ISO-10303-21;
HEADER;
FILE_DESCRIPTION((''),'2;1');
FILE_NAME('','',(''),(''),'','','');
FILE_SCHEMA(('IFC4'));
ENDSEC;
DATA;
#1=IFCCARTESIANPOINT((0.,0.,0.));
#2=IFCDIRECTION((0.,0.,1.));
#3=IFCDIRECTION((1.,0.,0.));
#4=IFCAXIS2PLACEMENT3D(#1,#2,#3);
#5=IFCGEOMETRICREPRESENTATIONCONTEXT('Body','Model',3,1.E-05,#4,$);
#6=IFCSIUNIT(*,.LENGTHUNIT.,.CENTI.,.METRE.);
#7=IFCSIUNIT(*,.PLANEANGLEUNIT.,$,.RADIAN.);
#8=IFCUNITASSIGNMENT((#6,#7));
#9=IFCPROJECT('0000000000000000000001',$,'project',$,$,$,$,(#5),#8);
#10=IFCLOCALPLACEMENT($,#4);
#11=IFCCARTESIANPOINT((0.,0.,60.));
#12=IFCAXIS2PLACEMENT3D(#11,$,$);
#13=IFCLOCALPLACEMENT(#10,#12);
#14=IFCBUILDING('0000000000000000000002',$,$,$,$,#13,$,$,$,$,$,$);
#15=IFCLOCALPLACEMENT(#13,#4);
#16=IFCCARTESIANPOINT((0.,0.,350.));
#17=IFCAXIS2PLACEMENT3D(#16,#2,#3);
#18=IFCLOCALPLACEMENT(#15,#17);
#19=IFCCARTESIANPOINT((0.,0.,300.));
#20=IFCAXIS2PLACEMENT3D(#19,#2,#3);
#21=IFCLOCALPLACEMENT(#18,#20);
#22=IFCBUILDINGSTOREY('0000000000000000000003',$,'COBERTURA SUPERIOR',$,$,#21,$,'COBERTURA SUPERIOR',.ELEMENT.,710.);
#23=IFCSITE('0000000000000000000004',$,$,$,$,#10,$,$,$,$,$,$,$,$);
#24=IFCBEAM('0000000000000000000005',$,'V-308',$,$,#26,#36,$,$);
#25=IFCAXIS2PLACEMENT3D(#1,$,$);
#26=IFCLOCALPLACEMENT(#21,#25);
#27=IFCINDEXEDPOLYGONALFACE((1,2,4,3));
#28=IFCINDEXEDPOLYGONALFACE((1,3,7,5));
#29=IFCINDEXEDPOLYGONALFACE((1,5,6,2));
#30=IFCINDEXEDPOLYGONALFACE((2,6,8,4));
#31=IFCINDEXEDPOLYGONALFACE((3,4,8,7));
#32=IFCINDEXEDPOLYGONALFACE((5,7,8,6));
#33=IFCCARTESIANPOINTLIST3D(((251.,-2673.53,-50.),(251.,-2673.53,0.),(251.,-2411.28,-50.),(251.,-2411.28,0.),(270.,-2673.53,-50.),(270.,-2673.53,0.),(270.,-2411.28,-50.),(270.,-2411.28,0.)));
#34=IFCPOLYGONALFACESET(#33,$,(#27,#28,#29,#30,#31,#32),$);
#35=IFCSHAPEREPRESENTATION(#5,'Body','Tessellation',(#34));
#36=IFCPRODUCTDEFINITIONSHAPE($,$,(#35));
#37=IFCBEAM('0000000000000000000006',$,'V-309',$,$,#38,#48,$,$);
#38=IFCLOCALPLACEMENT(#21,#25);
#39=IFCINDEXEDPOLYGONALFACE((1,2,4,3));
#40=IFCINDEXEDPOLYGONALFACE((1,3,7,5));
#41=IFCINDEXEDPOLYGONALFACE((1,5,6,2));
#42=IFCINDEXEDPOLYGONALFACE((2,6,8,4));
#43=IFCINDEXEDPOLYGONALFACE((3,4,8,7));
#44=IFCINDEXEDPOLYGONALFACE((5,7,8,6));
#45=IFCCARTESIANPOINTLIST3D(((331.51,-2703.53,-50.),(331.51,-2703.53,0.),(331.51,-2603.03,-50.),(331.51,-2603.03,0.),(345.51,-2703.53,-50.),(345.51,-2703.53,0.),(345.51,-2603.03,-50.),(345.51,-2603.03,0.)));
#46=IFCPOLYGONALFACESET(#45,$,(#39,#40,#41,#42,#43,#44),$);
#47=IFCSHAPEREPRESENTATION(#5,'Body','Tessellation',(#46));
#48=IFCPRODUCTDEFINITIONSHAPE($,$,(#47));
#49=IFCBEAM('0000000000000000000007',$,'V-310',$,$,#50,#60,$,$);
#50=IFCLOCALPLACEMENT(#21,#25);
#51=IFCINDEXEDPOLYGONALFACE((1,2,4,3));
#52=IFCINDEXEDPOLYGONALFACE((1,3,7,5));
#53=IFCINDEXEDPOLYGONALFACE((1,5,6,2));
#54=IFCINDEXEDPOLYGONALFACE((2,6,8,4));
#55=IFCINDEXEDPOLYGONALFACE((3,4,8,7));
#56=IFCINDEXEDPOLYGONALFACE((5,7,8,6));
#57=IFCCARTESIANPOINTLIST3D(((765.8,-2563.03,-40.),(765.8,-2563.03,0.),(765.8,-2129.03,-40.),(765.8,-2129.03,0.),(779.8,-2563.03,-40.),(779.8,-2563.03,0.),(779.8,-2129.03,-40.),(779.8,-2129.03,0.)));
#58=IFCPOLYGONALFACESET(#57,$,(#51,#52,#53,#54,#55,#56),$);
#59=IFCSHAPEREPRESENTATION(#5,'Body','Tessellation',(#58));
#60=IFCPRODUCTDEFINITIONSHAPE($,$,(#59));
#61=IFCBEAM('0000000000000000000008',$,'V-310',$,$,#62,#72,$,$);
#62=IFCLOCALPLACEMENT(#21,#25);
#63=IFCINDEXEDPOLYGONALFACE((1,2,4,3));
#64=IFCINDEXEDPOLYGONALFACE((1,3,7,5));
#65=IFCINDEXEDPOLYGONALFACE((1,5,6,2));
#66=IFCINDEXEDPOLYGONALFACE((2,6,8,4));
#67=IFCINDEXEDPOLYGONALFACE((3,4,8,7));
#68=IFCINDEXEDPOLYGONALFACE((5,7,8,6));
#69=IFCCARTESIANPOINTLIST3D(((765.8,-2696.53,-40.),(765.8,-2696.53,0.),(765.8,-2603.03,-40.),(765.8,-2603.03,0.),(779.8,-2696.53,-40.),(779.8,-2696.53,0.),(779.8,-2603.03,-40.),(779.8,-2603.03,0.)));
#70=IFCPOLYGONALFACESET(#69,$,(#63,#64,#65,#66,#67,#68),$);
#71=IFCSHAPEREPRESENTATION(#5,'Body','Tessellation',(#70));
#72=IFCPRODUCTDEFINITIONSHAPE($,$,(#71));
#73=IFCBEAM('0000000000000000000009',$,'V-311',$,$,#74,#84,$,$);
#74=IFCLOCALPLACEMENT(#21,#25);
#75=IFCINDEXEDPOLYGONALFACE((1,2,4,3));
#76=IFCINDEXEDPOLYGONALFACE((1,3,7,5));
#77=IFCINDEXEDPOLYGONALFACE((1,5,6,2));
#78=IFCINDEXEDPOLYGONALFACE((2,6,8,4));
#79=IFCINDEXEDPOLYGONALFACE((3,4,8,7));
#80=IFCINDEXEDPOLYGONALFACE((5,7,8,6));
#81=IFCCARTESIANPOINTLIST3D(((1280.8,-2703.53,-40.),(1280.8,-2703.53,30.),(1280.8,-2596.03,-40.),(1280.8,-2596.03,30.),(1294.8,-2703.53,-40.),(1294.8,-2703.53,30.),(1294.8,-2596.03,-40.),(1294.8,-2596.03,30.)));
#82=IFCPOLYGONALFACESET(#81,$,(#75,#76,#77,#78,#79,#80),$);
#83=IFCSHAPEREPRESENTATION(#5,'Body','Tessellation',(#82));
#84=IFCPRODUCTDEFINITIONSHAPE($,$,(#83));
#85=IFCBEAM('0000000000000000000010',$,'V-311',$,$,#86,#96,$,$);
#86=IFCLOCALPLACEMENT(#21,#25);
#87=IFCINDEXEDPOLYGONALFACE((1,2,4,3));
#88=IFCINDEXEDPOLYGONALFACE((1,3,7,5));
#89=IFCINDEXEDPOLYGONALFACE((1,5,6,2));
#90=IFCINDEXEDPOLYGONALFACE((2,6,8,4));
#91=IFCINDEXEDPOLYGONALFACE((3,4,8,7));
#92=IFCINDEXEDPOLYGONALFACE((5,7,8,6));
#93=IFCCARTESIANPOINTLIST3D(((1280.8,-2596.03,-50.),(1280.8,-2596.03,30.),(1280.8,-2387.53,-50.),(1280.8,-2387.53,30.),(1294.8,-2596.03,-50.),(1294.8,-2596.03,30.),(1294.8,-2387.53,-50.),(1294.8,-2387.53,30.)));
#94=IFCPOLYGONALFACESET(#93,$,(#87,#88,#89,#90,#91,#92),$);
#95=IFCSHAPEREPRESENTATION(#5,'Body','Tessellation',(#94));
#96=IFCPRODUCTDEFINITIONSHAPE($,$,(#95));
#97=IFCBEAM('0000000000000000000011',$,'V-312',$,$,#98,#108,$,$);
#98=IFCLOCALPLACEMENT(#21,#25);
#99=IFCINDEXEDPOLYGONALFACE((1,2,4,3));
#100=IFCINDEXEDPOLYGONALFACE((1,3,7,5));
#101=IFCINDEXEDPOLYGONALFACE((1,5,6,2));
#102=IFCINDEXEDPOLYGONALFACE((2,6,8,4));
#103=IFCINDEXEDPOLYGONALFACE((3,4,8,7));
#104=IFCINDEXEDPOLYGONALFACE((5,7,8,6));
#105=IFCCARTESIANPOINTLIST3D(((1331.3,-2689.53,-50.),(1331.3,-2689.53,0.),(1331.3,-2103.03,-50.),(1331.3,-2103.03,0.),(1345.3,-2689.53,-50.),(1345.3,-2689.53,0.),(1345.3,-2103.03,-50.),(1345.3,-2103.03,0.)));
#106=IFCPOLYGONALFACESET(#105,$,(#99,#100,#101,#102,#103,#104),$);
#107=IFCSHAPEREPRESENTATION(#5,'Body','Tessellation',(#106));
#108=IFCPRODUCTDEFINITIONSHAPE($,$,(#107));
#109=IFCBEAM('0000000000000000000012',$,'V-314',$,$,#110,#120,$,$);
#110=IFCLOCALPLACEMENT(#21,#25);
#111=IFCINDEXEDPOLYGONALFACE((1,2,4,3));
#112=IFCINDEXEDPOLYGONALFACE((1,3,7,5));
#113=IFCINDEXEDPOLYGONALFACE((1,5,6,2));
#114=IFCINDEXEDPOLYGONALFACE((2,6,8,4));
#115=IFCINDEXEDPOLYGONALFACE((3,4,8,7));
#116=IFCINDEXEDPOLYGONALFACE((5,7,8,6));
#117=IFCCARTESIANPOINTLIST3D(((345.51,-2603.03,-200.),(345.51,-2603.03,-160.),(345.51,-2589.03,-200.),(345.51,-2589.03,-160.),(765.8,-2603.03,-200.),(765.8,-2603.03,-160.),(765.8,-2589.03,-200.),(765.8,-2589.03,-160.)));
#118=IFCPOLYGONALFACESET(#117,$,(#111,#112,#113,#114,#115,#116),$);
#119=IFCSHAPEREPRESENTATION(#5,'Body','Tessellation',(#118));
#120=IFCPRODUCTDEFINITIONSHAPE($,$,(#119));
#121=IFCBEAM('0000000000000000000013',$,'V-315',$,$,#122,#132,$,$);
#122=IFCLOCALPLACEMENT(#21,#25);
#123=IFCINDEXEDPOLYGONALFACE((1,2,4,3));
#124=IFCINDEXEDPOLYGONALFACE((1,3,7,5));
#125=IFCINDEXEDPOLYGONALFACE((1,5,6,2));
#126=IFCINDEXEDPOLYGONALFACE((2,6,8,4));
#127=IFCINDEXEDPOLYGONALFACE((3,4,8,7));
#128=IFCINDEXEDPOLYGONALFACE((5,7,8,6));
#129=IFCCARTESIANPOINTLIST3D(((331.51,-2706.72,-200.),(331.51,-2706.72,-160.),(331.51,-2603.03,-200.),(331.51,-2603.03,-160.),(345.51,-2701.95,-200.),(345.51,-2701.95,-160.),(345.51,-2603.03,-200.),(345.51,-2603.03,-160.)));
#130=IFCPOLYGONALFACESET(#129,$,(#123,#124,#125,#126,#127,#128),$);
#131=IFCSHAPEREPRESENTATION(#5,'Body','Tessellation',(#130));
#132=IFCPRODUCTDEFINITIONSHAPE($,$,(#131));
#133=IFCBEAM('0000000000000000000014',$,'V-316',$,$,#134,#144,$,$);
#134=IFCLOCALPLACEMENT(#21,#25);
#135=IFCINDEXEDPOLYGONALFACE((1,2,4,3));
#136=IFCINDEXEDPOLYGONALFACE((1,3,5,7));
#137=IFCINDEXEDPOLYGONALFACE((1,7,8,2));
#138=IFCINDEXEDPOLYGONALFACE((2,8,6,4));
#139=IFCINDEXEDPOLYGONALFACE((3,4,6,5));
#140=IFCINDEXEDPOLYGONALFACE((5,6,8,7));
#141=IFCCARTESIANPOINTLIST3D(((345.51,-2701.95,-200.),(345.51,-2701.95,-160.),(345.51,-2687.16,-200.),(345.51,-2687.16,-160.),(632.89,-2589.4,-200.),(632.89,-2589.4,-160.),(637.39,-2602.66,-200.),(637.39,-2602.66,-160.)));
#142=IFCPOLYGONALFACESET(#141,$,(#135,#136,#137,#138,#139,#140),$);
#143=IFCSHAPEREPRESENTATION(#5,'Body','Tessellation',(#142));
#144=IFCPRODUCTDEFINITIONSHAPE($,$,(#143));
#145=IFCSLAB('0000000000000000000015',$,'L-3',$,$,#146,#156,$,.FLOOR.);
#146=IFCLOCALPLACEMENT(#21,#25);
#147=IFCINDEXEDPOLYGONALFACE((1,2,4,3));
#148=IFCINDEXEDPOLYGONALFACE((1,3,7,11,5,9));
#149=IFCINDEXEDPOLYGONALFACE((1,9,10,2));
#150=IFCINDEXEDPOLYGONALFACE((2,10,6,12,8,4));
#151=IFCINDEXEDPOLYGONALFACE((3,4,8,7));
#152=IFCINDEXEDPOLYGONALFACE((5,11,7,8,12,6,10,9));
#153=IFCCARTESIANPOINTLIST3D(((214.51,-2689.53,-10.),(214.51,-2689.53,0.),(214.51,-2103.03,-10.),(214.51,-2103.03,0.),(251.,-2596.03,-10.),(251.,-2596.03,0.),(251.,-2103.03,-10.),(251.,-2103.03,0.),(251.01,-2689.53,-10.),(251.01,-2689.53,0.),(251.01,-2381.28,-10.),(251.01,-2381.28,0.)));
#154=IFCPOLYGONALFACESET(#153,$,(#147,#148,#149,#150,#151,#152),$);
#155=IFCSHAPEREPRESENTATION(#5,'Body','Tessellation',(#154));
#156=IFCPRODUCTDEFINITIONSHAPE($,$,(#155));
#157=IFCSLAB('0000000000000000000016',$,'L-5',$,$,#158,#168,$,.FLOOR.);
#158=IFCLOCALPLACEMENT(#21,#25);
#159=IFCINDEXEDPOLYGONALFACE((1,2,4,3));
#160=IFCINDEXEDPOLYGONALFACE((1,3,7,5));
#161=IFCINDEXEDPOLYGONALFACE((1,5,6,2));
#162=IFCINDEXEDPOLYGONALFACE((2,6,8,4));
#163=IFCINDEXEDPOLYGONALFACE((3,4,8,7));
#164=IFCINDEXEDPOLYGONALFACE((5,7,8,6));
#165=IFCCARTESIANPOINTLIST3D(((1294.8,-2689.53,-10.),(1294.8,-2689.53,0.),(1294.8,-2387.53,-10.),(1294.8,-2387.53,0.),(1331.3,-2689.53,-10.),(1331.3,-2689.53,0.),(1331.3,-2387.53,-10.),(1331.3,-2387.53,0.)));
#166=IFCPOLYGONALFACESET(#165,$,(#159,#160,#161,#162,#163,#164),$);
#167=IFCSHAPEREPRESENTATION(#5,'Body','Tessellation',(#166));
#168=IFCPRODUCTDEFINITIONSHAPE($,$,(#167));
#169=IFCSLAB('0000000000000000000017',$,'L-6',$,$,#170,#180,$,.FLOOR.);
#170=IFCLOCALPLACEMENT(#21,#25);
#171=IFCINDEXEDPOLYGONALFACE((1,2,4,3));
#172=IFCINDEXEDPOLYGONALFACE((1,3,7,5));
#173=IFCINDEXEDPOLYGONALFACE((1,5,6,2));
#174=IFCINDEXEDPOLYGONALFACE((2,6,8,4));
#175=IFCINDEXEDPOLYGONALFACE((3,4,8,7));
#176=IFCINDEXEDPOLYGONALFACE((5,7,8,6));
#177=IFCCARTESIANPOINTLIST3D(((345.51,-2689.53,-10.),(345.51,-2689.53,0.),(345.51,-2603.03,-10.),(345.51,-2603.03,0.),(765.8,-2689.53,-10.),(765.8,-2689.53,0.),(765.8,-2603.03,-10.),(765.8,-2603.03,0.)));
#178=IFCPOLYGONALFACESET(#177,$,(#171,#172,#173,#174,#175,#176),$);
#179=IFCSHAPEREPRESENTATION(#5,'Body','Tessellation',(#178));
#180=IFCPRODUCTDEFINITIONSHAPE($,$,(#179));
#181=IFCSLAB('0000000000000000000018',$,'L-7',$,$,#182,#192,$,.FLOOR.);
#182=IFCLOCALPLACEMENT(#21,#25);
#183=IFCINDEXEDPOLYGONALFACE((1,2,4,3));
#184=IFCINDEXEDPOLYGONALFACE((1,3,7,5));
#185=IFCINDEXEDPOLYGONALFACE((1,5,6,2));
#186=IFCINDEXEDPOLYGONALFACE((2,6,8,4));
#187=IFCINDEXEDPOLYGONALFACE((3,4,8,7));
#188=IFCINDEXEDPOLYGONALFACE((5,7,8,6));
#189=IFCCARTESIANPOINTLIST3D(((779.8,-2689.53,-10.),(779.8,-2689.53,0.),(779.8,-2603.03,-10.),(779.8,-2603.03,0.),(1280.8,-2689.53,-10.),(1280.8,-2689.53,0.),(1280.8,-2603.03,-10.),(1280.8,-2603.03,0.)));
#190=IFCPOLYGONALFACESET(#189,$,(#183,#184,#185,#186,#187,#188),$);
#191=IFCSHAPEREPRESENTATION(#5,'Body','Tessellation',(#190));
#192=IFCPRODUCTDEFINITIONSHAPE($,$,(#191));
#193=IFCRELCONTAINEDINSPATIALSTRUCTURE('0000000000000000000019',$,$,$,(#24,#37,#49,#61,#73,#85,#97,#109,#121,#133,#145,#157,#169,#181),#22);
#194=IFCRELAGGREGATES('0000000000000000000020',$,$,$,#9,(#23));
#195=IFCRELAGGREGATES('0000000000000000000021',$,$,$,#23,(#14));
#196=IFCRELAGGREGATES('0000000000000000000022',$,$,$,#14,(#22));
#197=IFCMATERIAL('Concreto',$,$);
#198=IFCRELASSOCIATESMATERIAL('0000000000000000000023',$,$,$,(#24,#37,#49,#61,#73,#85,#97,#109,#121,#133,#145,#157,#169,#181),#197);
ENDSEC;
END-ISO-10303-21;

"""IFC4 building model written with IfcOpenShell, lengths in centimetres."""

from ifc_helpers import new_model, si_unit, frame, origin_with_axes, origin_2d_with_axis, place, context, project, spatial, polyline, rectangle, outline, extrude, clip, halfspace, material, element, save


model = new_model("IFC4")

# Units and contexts
model_context = context("Model", 3, precision=1e-05, world=origin_with_axes(), identifier="Body")
ifc_project = project(units=[si_unit("LENGTHUNIT", "METRE", prefix="CENTI"), si_unit("PLANEANGLEUNIT", "RADIAN")], contexts=[model_context])

# Site, building, storey
site_placement = place(None, origin_with_axes())
site = spatial("IfcSite", under=ifc_project, at=site_placement)
building_placement = place(site_placement, frame((0.0, 0.0, 60.0)))
building = spatial("IfcBuilding", under=site, at=building_placement)
placement_1 = place(building_placement, origin_with_axes())
placement_2 = place(placement_1, frame((0.0, 0.0, 350.0), z_axis=(0.0, 0.0, 1.0), x_axis=(1.0, 0.0, 0.0)))
storey_placement = place(placement_2, frame((0.0, 0.0, 300.0), z_axis=(0.0, 0.0, 1.0), x_axis=(1.0, 0.0, 0.0)))
storey = spatial("IfcBuildingStorey", under=building, at=storey_placement, Name="COBERTURA SUPERIOR", LongName="COBERTURA SUPERIOR", CompositionType="ELEMENT", Elevation=710.0)

# Shared definitions
ifc_material = material(Name="Concreto")

# Beams
beam_1_placement = place(storey_placement, frame((260.5, -2542.41, 0.0), z_axis=(0.0, 0.0, 1.0), x_axis=(1.0, 0.0, 0.0)))
element("IfcBeam", 1, at=beam_1_placement, inside=storey, material=ifc_material, Name="V-308", context=model_context, shape_type="SolidModel", body=[
    extrude(rectangle(XDim=19.0, YDim=50.0, at=origin_2d_with_axis()), frame((0.0, -131.12, -25.0), z_axis=(0.0, 1.0, 0.0), x_axis=(1.0, 0.0, 0.0)), (0.0, 0.0, 1.0), 262.25),
])
beam_2_placement = place(storey_placement, frame((338.51, -2653.28, 0.0), z_axis=(0.0, 0.0, 1.0), x_axis=(1.0, 0.0, 0.0)))
element("IfcBeam", 2, at=beam_2_placement, inside=storey, material=ifc_material, Name="V-309", context=model_context, shape_type="SolidModel", body=[
    extrude(rectangle(XDim=14.0, YDim=50.0, at=origin_2d_with_axis()), frame((0.0, -50.25, -25.0), z_axis=(0.0, 1.0, 0.0), x_axis=(1.0, 0.0, 0.0)), (0.0, 0.0, 1.0), 100.5),
])
beam_3_placement = place(storey_placement, frame((772.8, -2346.03, 0.0), z_axis=(0.0, 0.0, 1.0), x_axis=(1.0, 0.0, 0.0)))
element("IfcBeam", 3, at=beam_3_placement, inside=storey, material=ifc_material, Name="V-310", context=model_context, shape_type="SolidModel", body=[
    extrude(rectangle(XDim=14.0, YDim=40.0, at=origin_2d_with_axis()), frame((0.0, -217.0, -20.0), z_axis=(0.0, 1.0, 0.0), x_axis=(1.0, 0.0, 0.0)), (0.0, 0.0, 1.0), 434.0),
])
beam_4_placement = place(storey_placement, frame((772.8, -2649.78, 0.0), z_axis=(0.0, 0.0, 1.0), x_axis=(1.0, 0.0, 0.0)))
element("IfcBeam", 4, at=beam_4_placement, inside=storey, material=ifc_material, Name="V-310", context=model_context, shape_type="SolidModel", body=[
    extrude(rectangle(XDim=14.0, YDim=40.0, at=origin_2d_with_axis()), frame((0.0, -46.75, -20.0), z_axis=(0.0, 1.0, 0.0), x_axis=(1.0, 0.0, 0.0)), (0.0, 0.0, 1.0), 93.5),
])
beam_5_placement = place(storey_placement, frame((1287.8, -2649.78, 30.0), z_axis=(0.0, 0.0, 1.0), x_axis=(1.0, 0.0, 0.0)))
element("IfcBeam", 5, at=beam_5_placement, inside=storey, material=ifc_material, Name="V-311", context=model_context, shape_type="SolidModel", body=[
    extrude(rectangle(XDim=14.0, YDim=70.0, at=origin_2d_with_axis()), frame((0.0, -53.75, -35.0), z_axis=(0.0, 1.0, 0.0), x_axis=(1.0, 0.0, 0.0)), (0.0, 0.0, 1.0), 107.5),
])
beam_6_placement = place(storey_placement, frame((1287.8, -2491.78, 30.0), z_axis=(0.0, 0.0, 1.0), x_axis=(1.0, 0.0, 0.0)))
element("IfcBeam", 6, at=beam_6_placement, inside=storey, material=ifc_material, Name="V-311", context=model_context, shape_type="SolidModel", body=[
    extrude(rectangle(XDim=14.0, YDim=80.0, at=origin_2d_with_axis()), frame((0.0, -104.25, -40.0), z_axis=(0.0, 1.0, 0.0), x_axis=(1.0, 0.0, 0.0)), (0.0, 0.0, 1.0), 208.5),
])
beam_7_placement = place(storey_placement, frame((1338.3, -2396.28, 0.0), z_axis=(0.0, 0.0, 1.0), x_axis=(1.0, 0.0, 0.0)))
element("IfcBeam", 7, at=beam_7_placement, inside=storey, material=ifc_material, Name="V-312", context=model_context, shape_type="SolidModel", body=[
    extrude(rectangle(XDim=14.0, YDim=50.0, at=origin_2d_with_axis()), frame((0.0, -293.25, -25.0), z_axis=(0.0, 1.0, 0.0), x_axis=(1.0, 0.0, 0.0)), (0.0, 0.0, 1.0), 586.5),
])
beam_8_placement = place(storey_placement, frame((555.65, -2596.03, -160.0), z_axis=(0.0, 0.0, 1.0), x_axis=(1.0, 0.0, 0.0)))
element("IfcBeam", 8, at=beam_8_placement, inside=storey, material=ifc_material, Name="V-314", context=model_context, shape_type="SolidModel", body=[
    extrude(rectangle(XDim=14.0, YDim=40.0, at=origin_2d_with_axis()), frame((-210.15, 0.0, -20.0), z_axis=(1.0, 0.0, 0.0), x_axis=(0.0, -1.0, 0.0)), (0.0, 0.0, 1.0), 420.29),
])
beam_9_placement = place(storey_placement, frame((338.51, -2654.87, -160.0), z_axis=(0.0, 0.0, 1.0), x_axis=(1.0, 0.0, 0.0)))
element("IfcBeam", 9, at=beam_9_placement, inside=storey, material=ifc_material, Name="V-315", context=model_context, shape_type="Clipping", body=[
    clip(extrude(rectangle(XDim=14.0, YDim=40.0, at=origin_2d_with_axis()), frame((0.0, -51.84, -20.0), z_axis=(0.0, 1.0, 0.0), x_axis=(1.0, 0.0, 0.0)), (0.0, 0.0, 1.0), 103.69), halfspace(frame((-7.0, -51.84, 0.0), z_axis=(-0.322062, 0.946718, 0.0), x_axis=(0.0, 0.0, -0.322062)), True)),
])
beam_10_placement = place(storey_placement, frame((491.45, -2645.68, -160.0), z_axis=(0.0, 0.0, 1.0), x_axis=(1.0, 0.0, 0.0)))
element("IfcBeam", 10, at=beam_10_placement, inside=storey, material=ifc_material, Name="V-316", context=model_context, shape_type="Clipping", body=[
    clip(extrude(rectangle(XDim=14.0, YDim=40.0, at=origin_2d_with_axis()), frame((-148.2, -49.65, -20.0), z_axis=(0.946718, 0.322062, 0.0), x_axis=(0.322062, -0.946718, 0.0)), (0.0, 0.0, 1.0), 308.31), halfspace(frame((-145.94, -41.49, 0.0), z_axis=(1.0, 0.0, 0.0), x_axis=(0.0, 0.0, 0.322062)), True)),
])

# Slabs
slab_1_placement = place(storey_placement, frame((232.76, -2396.28, 0.0), z_axis=(0.0, 0.0, 1.0), x_axis=(1.0, 0.0, 0.0)))
element("IfcSlab", 11, at=slab_1_placement, inside=storey, material=ifc_material, Name="L-3", PredefinedType="FLOOR", context=model_context, shape_type="SolidModel", body=[
    extrude(outline(polyline([(18.25, -293.25), (18.24, -199.75), (18.25, 15.0), (18.24, 293.25), (-18.25, 293.25), (-18.25, -293.25), (18.25, -293.25), (18.25, -293.25)])), frame((0.0, 0.0, -10.0), z_axis=(0.0, 0.0, 1.0), x_axis=(1.0, 0.0, 0.0)), (0.0, 0.0, 1.0), 10.0),
])
slab_2_placement = place(storey_placement, frame((1313.05, -2538.53, 0.0), z_axis=(0.0, 0.0, 1.0), x_axis=(1.0, 0.0, 0.0)))
element("IfcSlab", 12, at=slab_2_placement, inside=storey, material=ifc_material, Name="L-5", PredefinedType="FLOOR", context=model_context, shape_type="SolidModel", body=[
    extrude(outline(polyline([(18.25, 151.0), (-18.25, 151.0), (-18.25, -151.0), (18.25, -151.0), (18.25, 151.0), (18.25, 151.0)])), frame((0.0, 0.0, -10.0), z_axis=(0.0, 0.0, 1.0), x_axis=(1.0, 0.0, 0.0)), (0.0, 0.0, 1.0), 10.0),
])
slab_3_placement = place(storey_placement, frame((555.65, -2646.28, 0.0), z_axis=(0.0, 0.0, 1.0), x_axis=(1.0, 0.0, 0.0)))
element("IfcSlab", 13, at=slab_3_placement, inside=storey, material=ifc_material, Name="L-6", PredefinedType="FLOOR", context=model_context, shape_type="SolidModel", body=[
    extrude(outline(polyline([(210.14, 43.25), (-210.15, 43.25), (-210.15, -43.25), (210.15, -43.25), (210.14, 43.25), (210.14, 43.25)])), frame((0.0, 0.0, -10.0), z_axis=(0.0, 0.0, 1.0), x_axis=(1.0, 0.0, 0.0)), (0.0, 0.0, 1.0), 10.0),
])
slab_4_placement = place(storey_placement, frame((1030.3, -2646.28, 0.0), z_axis=(0.0, 0.0, 1.0), x_axis=(1.0, 0.0, 0.0)))
element("IfcSlab", 14, at=slab_4_placement, inside=storey, material=ifc_material, Name="L-7", PredefinedType="FLOOR", context=model_context, shape_type="SolidModel", body=[
    extrude(outline(polyline([(250.5, 43.25), (-250.5, 43.25), (-250.5, -43.25), (250.5, -43.25), (250.5, 43.25), (250.5, 43.25)])), frame((0.0, 0.0, -10.0), z_axis=(0.0, 0.0, 1.0), x_axis=(1.0, 0.0, 0.0)), (0.0, 0.0, 1.0), 10.0),
])

save(model, "model.ifc")
